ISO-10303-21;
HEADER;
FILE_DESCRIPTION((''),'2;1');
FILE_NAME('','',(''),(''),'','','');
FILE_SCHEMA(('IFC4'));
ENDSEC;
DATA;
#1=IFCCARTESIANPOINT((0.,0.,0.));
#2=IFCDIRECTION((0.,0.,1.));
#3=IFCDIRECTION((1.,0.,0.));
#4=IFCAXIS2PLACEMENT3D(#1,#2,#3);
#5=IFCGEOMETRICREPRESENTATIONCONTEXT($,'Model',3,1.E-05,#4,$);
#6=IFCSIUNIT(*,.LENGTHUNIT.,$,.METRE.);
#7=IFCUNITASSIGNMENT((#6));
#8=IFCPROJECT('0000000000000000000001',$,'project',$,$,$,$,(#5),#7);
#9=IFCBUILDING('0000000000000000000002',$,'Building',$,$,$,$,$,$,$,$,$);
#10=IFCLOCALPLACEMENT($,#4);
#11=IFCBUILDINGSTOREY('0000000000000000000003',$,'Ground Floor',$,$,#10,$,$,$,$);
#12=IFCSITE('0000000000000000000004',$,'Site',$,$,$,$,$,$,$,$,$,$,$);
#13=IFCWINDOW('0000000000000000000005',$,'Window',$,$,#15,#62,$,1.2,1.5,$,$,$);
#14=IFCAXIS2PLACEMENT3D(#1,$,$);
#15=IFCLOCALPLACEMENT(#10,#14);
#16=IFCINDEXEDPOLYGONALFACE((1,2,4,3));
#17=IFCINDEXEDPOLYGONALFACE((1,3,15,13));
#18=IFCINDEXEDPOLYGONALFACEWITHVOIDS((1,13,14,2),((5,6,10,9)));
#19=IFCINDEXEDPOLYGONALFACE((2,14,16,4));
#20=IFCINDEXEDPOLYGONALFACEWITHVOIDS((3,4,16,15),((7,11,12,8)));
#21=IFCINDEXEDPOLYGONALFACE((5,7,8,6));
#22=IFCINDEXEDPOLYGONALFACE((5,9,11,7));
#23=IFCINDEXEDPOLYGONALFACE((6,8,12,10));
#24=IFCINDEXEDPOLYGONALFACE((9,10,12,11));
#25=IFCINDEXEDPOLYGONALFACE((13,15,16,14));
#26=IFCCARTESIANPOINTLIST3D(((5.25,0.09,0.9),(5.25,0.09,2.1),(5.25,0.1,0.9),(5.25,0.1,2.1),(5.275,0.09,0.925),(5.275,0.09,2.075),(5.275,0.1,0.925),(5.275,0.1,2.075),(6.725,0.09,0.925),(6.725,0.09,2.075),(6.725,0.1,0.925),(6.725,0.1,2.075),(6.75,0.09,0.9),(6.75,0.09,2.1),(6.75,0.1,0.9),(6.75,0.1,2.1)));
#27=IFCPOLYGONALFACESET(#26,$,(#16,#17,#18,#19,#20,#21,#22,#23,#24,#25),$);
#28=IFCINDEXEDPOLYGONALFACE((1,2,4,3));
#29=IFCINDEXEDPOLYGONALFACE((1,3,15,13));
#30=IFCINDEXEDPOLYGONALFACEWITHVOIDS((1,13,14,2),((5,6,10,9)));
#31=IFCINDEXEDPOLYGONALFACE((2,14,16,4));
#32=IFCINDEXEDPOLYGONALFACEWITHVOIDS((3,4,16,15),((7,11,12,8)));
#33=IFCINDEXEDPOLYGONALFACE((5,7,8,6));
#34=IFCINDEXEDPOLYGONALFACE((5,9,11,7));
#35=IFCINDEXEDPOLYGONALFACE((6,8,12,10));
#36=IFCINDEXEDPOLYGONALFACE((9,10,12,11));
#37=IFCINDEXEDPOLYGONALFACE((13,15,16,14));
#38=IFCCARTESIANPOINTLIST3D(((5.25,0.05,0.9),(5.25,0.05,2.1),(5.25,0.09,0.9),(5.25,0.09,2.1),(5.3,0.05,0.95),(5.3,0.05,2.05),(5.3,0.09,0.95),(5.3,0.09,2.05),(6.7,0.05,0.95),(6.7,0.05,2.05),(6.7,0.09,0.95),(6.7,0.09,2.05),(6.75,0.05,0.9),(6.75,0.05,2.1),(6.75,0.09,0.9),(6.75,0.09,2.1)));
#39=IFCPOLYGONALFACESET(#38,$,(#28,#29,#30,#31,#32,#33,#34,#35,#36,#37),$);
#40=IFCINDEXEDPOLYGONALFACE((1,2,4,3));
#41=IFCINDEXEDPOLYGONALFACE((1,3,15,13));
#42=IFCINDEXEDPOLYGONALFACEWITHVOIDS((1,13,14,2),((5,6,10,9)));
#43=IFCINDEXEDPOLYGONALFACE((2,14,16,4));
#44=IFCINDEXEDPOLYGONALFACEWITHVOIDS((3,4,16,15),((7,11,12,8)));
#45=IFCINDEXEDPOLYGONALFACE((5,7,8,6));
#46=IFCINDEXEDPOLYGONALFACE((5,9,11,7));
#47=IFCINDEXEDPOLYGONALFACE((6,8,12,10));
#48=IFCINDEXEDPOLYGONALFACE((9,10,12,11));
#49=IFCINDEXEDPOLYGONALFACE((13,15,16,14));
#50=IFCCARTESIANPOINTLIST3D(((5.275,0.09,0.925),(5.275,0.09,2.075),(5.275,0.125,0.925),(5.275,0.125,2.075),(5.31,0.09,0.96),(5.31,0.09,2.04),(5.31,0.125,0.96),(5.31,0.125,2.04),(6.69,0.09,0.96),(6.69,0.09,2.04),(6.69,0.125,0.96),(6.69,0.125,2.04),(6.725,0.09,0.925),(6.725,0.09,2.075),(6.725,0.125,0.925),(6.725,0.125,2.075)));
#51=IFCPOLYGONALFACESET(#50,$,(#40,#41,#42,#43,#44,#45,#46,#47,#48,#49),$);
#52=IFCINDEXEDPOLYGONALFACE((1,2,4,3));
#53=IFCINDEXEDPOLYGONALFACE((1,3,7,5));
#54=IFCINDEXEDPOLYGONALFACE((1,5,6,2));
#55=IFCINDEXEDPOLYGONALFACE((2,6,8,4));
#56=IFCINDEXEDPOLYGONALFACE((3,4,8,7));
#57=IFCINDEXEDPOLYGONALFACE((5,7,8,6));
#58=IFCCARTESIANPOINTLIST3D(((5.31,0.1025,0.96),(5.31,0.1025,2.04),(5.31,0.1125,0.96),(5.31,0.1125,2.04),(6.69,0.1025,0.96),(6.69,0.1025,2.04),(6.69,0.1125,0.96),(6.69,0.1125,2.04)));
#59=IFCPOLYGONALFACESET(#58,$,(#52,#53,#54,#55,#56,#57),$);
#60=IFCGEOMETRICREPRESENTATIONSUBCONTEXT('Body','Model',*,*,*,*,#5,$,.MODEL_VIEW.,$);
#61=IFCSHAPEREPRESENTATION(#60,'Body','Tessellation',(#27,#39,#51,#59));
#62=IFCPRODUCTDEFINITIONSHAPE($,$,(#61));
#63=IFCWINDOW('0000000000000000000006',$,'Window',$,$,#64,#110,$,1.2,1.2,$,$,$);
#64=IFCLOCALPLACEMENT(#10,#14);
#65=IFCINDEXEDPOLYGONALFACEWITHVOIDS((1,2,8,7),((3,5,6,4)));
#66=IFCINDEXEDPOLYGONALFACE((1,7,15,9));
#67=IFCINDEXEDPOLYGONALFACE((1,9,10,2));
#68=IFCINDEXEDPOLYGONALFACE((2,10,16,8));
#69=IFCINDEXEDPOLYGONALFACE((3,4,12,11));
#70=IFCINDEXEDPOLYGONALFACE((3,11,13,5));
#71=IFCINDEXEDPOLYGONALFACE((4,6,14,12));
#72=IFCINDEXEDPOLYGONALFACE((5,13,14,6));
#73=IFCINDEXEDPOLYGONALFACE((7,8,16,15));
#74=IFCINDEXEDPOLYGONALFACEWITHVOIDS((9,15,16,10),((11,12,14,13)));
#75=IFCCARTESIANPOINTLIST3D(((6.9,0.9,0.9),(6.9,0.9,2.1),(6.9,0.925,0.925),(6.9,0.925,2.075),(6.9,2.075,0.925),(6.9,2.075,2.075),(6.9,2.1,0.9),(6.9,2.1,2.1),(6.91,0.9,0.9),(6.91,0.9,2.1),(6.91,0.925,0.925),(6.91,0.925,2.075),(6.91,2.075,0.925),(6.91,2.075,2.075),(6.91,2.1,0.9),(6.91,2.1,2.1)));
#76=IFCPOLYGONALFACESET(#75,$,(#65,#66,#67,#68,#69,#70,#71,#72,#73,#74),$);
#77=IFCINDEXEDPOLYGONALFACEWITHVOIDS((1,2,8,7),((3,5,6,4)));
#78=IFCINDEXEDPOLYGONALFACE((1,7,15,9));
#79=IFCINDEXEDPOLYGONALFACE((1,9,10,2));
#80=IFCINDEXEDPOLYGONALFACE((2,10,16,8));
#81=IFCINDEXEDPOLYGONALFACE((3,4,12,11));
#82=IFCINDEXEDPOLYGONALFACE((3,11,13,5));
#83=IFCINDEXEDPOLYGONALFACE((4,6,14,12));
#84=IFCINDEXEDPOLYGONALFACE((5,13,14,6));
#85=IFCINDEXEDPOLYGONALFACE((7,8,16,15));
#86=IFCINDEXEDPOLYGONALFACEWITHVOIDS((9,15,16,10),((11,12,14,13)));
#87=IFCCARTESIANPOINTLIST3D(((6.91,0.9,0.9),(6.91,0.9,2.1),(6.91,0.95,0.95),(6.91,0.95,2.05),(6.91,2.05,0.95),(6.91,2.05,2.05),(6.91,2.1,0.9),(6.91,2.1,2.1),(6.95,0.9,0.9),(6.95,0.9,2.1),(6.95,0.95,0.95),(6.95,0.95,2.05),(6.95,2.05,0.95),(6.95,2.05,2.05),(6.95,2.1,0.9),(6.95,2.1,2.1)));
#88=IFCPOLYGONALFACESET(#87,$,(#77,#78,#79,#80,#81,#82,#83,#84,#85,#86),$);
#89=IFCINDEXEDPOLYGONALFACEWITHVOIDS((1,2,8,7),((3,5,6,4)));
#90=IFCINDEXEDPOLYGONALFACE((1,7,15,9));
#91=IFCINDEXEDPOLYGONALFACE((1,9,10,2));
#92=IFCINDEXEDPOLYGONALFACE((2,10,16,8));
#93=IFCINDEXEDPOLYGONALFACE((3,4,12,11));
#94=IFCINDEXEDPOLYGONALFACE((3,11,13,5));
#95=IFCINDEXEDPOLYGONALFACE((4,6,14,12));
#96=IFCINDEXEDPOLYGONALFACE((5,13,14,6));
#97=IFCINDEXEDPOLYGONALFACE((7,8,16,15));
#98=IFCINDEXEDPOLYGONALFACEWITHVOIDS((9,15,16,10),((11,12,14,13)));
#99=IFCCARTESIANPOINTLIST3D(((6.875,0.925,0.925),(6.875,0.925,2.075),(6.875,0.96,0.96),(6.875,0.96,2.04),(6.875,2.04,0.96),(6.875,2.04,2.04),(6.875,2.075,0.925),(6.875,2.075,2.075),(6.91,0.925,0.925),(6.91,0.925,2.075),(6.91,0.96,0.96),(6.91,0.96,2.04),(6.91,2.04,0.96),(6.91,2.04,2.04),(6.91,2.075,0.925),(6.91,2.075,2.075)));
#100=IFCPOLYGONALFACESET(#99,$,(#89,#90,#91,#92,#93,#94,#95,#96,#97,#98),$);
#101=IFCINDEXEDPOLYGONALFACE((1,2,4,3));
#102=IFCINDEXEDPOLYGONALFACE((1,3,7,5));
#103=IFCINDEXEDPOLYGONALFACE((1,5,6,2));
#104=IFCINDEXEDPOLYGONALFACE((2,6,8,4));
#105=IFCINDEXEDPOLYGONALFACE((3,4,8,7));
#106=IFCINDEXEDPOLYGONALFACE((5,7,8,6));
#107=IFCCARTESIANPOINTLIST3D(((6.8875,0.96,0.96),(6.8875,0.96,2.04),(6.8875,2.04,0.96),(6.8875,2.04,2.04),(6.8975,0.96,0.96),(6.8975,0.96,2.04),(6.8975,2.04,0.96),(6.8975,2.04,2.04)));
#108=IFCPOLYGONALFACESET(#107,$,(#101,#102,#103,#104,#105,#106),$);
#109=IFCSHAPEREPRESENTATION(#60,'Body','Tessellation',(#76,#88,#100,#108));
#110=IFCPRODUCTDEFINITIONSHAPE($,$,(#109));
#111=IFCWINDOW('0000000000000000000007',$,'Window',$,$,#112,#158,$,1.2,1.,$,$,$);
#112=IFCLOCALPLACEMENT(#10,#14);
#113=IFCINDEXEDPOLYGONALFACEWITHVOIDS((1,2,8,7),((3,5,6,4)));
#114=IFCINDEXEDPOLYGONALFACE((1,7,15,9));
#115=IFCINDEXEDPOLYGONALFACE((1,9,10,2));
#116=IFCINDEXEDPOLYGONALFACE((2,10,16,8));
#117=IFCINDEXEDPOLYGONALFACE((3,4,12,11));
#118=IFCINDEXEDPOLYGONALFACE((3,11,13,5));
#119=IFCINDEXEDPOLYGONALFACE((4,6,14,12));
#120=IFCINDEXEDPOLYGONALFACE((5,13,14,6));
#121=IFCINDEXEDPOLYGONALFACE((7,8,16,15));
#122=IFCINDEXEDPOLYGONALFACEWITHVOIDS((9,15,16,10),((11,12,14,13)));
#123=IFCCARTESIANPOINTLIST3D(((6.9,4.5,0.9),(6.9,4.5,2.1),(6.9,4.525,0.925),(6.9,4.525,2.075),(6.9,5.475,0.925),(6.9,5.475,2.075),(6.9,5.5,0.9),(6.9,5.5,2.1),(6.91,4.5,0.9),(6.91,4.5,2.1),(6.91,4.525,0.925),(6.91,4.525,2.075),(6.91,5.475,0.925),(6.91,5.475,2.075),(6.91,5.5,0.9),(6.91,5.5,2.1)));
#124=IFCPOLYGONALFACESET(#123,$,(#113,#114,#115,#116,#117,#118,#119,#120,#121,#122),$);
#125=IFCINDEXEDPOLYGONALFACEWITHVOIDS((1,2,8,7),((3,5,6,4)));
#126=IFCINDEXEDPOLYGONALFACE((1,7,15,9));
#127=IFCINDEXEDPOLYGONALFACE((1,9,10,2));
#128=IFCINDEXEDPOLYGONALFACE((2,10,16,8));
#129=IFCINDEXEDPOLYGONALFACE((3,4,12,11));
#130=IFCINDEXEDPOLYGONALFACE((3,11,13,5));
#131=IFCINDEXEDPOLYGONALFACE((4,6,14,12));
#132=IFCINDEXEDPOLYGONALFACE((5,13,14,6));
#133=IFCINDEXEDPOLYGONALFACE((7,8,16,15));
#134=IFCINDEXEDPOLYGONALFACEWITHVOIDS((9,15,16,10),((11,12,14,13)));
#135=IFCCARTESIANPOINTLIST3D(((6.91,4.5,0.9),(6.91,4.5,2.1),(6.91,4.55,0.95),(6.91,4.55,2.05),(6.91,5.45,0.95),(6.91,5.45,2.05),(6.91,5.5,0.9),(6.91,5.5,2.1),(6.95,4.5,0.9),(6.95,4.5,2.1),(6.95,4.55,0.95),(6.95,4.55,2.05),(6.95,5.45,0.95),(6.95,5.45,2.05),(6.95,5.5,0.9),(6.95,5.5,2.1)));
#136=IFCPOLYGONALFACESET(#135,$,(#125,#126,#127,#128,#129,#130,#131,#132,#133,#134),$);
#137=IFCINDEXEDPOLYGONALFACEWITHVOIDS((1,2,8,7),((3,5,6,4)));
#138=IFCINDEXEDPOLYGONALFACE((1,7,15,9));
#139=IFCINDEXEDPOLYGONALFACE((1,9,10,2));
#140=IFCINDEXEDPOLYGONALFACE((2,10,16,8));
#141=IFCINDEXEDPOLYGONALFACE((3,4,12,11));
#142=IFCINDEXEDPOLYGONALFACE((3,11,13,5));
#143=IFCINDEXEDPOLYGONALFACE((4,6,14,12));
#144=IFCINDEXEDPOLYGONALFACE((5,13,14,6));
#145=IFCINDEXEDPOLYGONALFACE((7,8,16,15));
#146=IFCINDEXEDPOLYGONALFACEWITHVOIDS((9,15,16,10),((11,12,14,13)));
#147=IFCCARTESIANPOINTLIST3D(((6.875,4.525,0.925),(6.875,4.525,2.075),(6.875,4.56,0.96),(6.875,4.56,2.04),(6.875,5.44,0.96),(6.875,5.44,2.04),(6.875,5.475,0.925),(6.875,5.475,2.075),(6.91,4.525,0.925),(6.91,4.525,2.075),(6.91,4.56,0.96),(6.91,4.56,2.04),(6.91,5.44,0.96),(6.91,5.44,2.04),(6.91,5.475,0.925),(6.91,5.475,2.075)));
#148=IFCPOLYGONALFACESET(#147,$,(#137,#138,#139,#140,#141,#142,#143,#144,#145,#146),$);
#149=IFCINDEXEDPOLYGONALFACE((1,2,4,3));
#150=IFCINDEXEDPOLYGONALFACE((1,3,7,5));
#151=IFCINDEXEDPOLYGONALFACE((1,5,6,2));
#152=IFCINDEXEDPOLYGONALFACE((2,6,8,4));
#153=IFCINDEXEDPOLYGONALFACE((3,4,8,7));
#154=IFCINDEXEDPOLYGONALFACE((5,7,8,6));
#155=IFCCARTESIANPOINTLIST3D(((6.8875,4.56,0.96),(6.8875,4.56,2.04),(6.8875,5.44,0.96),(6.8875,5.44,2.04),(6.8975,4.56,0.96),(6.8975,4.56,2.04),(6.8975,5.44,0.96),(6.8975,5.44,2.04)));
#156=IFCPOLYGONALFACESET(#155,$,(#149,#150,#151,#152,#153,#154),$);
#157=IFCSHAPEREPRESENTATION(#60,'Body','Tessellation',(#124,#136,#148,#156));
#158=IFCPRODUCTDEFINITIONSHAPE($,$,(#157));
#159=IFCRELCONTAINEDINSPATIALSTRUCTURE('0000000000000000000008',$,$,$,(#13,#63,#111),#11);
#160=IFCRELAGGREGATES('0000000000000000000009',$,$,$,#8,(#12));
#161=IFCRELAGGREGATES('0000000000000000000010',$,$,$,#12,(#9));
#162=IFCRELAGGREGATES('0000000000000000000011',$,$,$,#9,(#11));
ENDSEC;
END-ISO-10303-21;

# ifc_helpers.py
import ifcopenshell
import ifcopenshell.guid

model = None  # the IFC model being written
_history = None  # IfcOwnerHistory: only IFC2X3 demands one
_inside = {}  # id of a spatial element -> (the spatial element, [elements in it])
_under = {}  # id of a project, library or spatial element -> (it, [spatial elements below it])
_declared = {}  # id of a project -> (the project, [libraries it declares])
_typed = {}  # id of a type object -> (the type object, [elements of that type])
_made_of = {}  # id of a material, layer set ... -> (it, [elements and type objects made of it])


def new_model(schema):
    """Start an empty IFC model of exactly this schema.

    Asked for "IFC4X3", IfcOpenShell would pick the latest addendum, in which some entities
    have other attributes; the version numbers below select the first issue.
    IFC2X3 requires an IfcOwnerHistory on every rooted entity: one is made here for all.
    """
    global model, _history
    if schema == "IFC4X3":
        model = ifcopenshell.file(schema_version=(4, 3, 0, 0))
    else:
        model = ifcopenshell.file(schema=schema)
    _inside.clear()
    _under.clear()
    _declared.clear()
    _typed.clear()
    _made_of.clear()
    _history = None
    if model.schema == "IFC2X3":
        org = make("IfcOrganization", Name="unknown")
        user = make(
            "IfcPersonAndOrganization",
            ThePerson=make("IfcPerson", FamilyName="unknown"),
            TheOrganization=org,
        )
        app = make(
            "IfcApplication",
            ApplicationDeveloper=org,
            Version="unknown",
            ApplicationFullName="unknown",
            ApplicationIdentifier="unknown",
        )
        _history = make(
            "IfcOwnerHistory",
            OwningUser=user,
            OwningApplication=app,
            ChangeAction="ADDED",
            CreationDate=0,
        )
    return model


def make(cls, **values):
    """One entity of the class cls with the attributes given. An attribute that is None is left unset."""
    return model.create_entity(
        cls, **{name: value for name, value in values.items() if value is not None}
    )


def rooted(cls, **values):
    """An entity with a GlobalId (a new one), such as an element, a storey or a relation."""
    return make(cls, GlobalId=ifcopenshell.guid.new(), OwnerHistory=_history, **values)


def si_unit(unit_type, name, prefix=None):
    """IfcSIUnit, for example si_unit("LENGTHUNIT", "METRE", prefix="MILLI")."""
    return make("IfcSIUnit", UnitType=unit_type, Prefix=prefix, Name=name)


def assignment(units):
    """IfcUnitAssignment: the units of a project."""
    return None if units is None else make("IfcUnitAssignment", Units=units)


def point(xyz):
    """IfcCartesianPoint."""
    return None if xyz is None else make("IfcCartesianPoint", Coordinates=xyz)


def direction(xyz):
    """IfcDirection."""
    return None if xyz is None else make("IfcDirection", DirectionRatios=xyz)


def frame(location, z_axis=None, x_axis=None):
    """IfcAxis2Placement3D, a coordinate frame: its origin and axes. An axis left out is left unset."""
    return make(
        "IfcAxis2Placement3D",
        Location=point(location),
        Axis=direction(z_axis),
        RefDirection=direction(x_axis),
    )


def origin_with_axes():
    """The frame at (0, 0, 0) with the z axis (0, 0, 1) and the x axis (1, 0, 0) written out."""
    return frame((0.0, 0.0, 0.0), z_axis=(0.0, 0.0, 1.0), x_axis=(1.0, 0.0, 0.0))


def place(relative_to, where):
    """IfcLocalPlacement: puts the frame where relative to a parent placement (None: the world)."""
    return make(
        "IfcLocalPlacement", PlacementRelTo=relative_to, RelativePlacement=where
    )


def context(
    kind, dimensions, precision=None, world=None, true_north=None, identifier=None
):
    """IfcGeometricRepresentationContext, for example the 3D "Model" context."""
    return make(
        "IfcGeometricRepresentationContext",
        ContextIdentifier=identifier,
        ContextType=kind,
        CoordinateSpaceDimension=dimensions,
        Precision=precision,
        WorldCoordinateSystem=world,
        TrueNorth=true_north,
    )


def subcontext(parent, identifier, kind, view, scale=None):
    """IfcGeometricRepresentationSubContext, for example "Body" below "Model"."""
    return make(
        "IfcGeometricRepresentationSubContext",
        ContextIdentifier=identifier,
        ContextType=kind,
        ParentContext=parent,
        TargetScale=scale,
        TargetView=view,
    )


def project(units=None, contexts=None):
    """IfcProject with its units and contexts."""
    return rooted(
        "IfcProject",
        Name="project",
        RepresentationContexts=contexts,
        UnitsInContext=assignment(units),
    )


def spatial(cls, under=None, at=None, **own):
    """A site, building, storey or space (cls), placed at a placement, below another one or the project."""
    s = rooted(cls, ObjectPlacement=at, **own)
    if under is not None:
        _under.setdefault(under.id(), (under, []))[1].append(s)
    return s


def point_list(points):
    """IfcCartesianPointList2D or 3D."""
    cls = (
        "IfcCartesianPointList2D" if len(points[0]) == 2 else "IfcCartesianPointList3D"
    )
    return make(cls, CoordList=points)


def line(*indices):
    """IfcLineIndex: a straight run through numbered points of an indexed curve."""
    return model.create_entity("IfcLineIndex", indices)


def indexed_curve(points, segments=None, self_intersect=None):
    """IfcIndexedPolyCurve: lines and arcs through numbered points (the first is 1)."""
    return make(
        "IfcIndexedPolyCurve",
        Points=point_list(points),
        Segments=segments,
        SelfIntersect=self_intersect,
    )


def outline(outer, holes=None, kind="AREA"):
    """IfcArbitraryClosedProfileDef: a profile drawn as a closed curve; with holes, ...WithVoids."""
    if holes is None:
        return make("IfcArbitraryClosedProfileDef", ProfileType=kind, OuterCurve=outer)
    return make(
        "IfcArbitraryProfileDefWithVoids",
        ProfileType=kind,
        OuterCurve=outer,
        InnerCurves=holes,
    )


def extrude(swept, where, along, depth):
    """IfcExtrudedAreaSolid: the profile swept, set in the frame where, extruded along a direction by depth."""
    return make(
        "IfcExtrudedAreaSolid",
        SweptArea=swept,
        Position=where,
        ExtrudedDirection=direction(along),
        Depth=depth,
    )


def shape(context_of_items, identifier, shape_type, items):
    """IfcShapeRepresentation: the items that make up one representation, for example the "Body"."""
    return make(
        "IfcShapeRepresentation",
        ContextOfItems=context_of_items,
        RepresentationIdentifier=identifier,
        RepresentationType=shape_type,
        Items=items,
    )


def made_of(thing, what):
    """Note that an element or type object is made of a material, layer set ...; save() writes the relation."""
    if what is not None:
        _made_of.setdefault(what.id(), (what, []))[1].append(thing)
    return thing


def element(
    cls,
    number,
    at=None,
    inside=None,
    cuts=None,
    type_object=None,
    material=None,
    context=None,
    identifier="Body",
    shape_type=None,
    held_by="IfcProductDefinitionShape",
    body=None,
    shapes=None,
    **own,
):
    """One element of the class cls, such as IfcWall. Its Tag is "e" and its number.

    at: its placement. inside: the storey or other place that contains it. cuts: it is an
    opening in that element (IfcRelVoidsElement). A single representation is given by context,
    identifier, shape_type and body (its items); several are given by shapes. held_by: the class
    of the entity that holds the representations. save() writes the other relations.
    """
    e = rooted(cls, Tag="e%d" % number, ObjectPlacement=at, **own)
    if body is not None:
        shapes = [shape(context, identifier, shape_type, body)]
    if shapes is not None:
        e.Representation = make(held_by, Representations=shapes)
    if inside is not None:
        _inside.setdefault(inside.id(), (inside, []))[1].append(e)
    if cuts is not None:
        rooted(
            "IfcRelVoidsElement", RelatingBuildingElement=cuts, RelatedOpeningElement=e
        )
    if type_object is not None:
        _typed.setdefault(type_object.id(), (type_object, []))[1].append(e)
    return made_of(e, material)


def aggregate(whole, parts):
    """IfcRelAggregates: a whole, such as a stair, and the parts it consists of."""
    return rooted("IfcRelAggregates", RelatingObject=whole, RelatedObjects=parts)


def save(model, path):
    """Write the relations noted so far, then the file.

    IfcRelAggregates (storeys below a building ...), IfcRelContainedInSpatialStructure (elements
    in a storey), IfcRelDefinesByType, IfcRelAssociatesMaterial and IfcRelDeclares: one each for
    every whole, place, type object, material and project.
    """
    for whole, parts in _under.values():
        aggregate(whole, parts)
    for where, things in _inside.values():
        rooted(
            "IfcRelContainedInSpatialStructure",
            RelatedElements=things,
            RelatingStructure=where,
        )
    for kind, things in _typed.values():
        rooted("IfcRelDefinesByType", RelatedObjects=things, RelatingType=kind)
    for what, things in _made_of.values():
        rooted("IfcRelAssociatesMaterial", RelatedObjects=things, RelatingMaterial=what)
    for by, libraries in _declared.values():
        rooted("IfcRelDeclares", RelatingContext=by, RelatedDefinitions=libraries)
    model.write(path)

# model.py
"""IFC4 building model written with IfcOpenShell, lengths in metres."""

from ifc_helpers import new_model, si_unit, frame, origin_with_axes, place, context, subcontext, project, spatial, line, indexed_curve, outline, extrude, element, save


model = new_model("IFC4")

# Units and contexts
model_context = context("Model", 3, precision=1e-05, world=origin_with_axes())
body_context = subcontext(model_context, "Body", "Model", "MODEL_VIEW")
ifc_project = project(units=[si_unit("LENGTHUNIT", "METRE")], contexts=[model_context])

# Site, building, storey
site = spatial("IfcSite", under=ifc_project, Name="Site")
building = spatial("IfcBuilding", under=site, Name="Building")
storey_placement = place(None, origin_with_axes())
storey = spatial("IfcBuildingStorey", under=building, at=storey_placement, Name="Ground Floor")

# Windows
window_1_placement = place(storey_placement, frame((5.25, 0.0, 0.9), z_axis=(0.0, 0.0, 1.0), x_axis=(1.0, 0.0, 0.0)))
element("IfcWindow", 1, at=window_1_placement, inside=storey, Name="Window", OverallHeight=1.2, OverallWidth=1.5, context=body_context, shape_type="SweptSolid", body=[
    extrude(outline(indexed_curve([(0.0, 0.0), (1.5, 0.0), (1.5, 1.2), (0.0, 1.2)], segments=[line(1, 2, 3, 4, 1)]), holes=[indexed_curve([(0.025, 0.025), (1.475, 0.025), (1.475, 1.175), (0.025, 1.175)], segments=[line(1, 2, 3, 4, 1)])]), frame((0.0, 0.09, 0.0), z_axis=(0.0, -1.0, 0.0), x_axis=(1.0, 0.0, 0.0)), (0.0, 0.0, -1.0), 0.01),
    extrude(outline(indexed_curve([(0.0, 0.0), (1.5, 0.0), (1.5, 1.2), (0.0, 1.2)], segments=[line(1, 2, 3, 4, 1)]), holes=[indexed_curve([(0.05, 0.05), (1.45, 0.05), (1.45, 1.15), (0.05, 1.15)], segments=[line(1, 2, 3, 4, 1)])]), frame((0.0, 0.05, 0.0), z_axis=(0.0, -1.0, 0.0), x_axis=(1.0, 0.0, 0.0)), (0.0, 0.0, -1.0), 0.04),
    extrude(outline(indexed_curve([(0.0, 0.0), (1.45, 0.0), (1.45, 1.15), (0.0, 1.15)], segments=[line(1, 2, 3, 4, 1)]), holes=[indexed_curve([(0.035, 0.035), (1.415, 0.035), (1.415, 1.115), (0.035, 1.115)], segments=[line(1, 2, 3, 4, 1)])]), frame((0.025, 0.09, 0.025), z_axis=(0.0, -1.0, 0.0), x_axis=(1.0, 0.0, 0.0)), (0.0, 0.0, -1.0), 0.035),
    extrude(outline(indexed_curve([(0.035, 0.035), (1.415, 0.035), (1.415, 1.115), (0.035, 1.115)], segments=[line(1, 2, 3, 4, 1)])), frame((0.025, 0.1025, 0.025), z_axis=(0.0, -1.0, 0.0), x_axis=(1.0, 0.0, 0.0)), (0.0, 0.0, -1.0), 0.01),
])
window_2_placement = place(storey_placement, frame((7.0, 0.9, 0.9), z_axis=(0.0, 0.0, 1.0), x_axis=(0.0, 1.0, 0.0)))
element("IfcWindow", 2, at=window_2_placement, inside=storey, Name="Window", OverallHeight=1.2, OverallWidth=1.2, context=body_context, shape_type="SweptSolid", body=[
    extrude(outline(indexed_curve([(0.0, 0.0), (1.2, 0.0), (1.2, 1.2), (0.0, 1.2)], segments=[line(1, 2, 3, 4, 1)]), holes=[indexed_curve([(0.025, 0.025), (1.175, 0.025), (1.175, 1.175), (0.025, 1.175)], segments=[line(1, 2, 3, 4, 1)])]), frame((0.0, 0.09, 0.0), z_axis=(0.0, -1.0, 0.0), x_axis=(1.0, 0.0, 0.0)), (0.0, 0.0, -1.0), 0.01),
    extrude(outline(indexed_curve([(0.0, 0.0), (1.2, 0.0), (1.2, 1.2), (0.0, 1.2)], segments=[line(1, 2, 3, 4, 1)]), holes=[indexed_curve([(0.05, 0.05), (1.15, 0.05), (1.15, 1.15), (0.05, 1.15)], segments=[line(1, 2, 3, 4, 1)])]), frame((0.0, 0.05, 0.0), z_axis=(0.0, -1.0, 0.0), x_axis=(1.0, 0.0, 0.0)), (0.0, 0.0, -1.0), 0.04),
    extrude(outline(indexed_curve([(0.0, 0.0), (1.15, 0.0), (1.15, 1.15), (0.0, 1.15)], segments=[line(1, 2, 3, 4, 1)]), holes=[indexed_curve([(0.035, 0.035), (1.115, 0.035), (1.115, 1.115), (0.035, 1.115)], segments=[line(1, 2, 3, 4, 1)])]), frame((0.025, 0.09, 0.025), z_axis=(0.0, -1.0, 0.0), x_axis=(1.0, 0.0, 0.0)), (0.0, 0.0, -1.0), 0.035),
    extrude(outline(indexed_curve([(0.035, 0.035), (1.115, 0.035), (1.115, 1.115), (0.035, 1.115)], segments=[line(1, 2, 3, 4, 1)])), frame((0.025, 0.1025, 0.025), z_axis=(0.0, -1.0, 0.0), x_axis=(1.0, 0.0, 0.0)), (0.0, 0.0, -1.0), 0.01),
])
window_3_placement = place(storey_placement, frame((7.0, 4.5, 0.9), z_axis=(0.0, 0.0, 1.0), x_axis=(0.0, 1.0, 0.0)))
element("IfcWindow", 3, at=window_3_placement, inside=storey, Name="Window", OverallHeight=1.2, OverallWidth=1.0, context=body_context, shape_type="SweptSolid", body=[
    extrude(outline(indexed_curve([(0.0, 0.0), (1.0, 0.0), (1.0, 1.2), (0.0, 1.2)], segments=[line(1, 2, 3, 4, 1)]), holes=[indexed_curve([(0.025, 0.025), (0.975, 0.025), (0.975, 1.175), (0.025, 1.175)], segments=[line(1, 2, 3, 4, 1)])]), frame((0.0, 0.09, 0.0), z_axis=(0.0, -1.0, 0.0), x_axis=(1.0, 0.0, 0.0)), (0.0, 0.0, -1.0), 0.01),
    extrude(outline(indexed_curve([(0.0, 0.0), (1.0, 0.0), (1.0, 1.2), (0.0, 1.2)], segments=[line(1, 2, 3, 4, 1)]), holes=[indexed_curve([(0.05, 0.05), (0.95, 0.05), (0.95, 1.15), (0.05, 1.15)], segments=[line(1, 2, 3, 4, 1)])]), frame((0.0, 0.05, 0.0), z_axis=(0.0, -1.0, 0.0), x_axis=(1.0, 0.0, 0.0)), (0.0, 0.0, -1.0), 0.04),
    extrude(outline(indexed_curve([(0.0, 0.0), (0.95, 0.0), (0.95, 1.15), (0.0, 1.15)], segments=[line(1, 2, 3, 4, 1)]), holes=[indexed_curve([(0.035, 0.035), (0.915, 0.035), (0.915, 1.115), (0.035, 1.115)], segments=[line(1, 2, 3, 4, 1)])]), frame((0.025, 0.09, 0.025), z_axis=(0.0, -1.0, 0.0), x_axis=(1.0, 0.0, 0.0)), (0.0, 0.0, -1.0), 0.035),
    extrude(outline(indexed_curve([(0.035, 0.035), (0.915, 0.035), (0.915, 1.115), (0.035, 1.115)], segments=[line(1, 2, 3, 4, 1)])), frame((0.025, 0.1025, 0.025), z_axis=(0.0, -1.0, 0.0), x_axis=(1.0, 0.0, 0.0)), (0.0, 0.0, -1.0), 0.01),
])

save(model, "model.ifc")
